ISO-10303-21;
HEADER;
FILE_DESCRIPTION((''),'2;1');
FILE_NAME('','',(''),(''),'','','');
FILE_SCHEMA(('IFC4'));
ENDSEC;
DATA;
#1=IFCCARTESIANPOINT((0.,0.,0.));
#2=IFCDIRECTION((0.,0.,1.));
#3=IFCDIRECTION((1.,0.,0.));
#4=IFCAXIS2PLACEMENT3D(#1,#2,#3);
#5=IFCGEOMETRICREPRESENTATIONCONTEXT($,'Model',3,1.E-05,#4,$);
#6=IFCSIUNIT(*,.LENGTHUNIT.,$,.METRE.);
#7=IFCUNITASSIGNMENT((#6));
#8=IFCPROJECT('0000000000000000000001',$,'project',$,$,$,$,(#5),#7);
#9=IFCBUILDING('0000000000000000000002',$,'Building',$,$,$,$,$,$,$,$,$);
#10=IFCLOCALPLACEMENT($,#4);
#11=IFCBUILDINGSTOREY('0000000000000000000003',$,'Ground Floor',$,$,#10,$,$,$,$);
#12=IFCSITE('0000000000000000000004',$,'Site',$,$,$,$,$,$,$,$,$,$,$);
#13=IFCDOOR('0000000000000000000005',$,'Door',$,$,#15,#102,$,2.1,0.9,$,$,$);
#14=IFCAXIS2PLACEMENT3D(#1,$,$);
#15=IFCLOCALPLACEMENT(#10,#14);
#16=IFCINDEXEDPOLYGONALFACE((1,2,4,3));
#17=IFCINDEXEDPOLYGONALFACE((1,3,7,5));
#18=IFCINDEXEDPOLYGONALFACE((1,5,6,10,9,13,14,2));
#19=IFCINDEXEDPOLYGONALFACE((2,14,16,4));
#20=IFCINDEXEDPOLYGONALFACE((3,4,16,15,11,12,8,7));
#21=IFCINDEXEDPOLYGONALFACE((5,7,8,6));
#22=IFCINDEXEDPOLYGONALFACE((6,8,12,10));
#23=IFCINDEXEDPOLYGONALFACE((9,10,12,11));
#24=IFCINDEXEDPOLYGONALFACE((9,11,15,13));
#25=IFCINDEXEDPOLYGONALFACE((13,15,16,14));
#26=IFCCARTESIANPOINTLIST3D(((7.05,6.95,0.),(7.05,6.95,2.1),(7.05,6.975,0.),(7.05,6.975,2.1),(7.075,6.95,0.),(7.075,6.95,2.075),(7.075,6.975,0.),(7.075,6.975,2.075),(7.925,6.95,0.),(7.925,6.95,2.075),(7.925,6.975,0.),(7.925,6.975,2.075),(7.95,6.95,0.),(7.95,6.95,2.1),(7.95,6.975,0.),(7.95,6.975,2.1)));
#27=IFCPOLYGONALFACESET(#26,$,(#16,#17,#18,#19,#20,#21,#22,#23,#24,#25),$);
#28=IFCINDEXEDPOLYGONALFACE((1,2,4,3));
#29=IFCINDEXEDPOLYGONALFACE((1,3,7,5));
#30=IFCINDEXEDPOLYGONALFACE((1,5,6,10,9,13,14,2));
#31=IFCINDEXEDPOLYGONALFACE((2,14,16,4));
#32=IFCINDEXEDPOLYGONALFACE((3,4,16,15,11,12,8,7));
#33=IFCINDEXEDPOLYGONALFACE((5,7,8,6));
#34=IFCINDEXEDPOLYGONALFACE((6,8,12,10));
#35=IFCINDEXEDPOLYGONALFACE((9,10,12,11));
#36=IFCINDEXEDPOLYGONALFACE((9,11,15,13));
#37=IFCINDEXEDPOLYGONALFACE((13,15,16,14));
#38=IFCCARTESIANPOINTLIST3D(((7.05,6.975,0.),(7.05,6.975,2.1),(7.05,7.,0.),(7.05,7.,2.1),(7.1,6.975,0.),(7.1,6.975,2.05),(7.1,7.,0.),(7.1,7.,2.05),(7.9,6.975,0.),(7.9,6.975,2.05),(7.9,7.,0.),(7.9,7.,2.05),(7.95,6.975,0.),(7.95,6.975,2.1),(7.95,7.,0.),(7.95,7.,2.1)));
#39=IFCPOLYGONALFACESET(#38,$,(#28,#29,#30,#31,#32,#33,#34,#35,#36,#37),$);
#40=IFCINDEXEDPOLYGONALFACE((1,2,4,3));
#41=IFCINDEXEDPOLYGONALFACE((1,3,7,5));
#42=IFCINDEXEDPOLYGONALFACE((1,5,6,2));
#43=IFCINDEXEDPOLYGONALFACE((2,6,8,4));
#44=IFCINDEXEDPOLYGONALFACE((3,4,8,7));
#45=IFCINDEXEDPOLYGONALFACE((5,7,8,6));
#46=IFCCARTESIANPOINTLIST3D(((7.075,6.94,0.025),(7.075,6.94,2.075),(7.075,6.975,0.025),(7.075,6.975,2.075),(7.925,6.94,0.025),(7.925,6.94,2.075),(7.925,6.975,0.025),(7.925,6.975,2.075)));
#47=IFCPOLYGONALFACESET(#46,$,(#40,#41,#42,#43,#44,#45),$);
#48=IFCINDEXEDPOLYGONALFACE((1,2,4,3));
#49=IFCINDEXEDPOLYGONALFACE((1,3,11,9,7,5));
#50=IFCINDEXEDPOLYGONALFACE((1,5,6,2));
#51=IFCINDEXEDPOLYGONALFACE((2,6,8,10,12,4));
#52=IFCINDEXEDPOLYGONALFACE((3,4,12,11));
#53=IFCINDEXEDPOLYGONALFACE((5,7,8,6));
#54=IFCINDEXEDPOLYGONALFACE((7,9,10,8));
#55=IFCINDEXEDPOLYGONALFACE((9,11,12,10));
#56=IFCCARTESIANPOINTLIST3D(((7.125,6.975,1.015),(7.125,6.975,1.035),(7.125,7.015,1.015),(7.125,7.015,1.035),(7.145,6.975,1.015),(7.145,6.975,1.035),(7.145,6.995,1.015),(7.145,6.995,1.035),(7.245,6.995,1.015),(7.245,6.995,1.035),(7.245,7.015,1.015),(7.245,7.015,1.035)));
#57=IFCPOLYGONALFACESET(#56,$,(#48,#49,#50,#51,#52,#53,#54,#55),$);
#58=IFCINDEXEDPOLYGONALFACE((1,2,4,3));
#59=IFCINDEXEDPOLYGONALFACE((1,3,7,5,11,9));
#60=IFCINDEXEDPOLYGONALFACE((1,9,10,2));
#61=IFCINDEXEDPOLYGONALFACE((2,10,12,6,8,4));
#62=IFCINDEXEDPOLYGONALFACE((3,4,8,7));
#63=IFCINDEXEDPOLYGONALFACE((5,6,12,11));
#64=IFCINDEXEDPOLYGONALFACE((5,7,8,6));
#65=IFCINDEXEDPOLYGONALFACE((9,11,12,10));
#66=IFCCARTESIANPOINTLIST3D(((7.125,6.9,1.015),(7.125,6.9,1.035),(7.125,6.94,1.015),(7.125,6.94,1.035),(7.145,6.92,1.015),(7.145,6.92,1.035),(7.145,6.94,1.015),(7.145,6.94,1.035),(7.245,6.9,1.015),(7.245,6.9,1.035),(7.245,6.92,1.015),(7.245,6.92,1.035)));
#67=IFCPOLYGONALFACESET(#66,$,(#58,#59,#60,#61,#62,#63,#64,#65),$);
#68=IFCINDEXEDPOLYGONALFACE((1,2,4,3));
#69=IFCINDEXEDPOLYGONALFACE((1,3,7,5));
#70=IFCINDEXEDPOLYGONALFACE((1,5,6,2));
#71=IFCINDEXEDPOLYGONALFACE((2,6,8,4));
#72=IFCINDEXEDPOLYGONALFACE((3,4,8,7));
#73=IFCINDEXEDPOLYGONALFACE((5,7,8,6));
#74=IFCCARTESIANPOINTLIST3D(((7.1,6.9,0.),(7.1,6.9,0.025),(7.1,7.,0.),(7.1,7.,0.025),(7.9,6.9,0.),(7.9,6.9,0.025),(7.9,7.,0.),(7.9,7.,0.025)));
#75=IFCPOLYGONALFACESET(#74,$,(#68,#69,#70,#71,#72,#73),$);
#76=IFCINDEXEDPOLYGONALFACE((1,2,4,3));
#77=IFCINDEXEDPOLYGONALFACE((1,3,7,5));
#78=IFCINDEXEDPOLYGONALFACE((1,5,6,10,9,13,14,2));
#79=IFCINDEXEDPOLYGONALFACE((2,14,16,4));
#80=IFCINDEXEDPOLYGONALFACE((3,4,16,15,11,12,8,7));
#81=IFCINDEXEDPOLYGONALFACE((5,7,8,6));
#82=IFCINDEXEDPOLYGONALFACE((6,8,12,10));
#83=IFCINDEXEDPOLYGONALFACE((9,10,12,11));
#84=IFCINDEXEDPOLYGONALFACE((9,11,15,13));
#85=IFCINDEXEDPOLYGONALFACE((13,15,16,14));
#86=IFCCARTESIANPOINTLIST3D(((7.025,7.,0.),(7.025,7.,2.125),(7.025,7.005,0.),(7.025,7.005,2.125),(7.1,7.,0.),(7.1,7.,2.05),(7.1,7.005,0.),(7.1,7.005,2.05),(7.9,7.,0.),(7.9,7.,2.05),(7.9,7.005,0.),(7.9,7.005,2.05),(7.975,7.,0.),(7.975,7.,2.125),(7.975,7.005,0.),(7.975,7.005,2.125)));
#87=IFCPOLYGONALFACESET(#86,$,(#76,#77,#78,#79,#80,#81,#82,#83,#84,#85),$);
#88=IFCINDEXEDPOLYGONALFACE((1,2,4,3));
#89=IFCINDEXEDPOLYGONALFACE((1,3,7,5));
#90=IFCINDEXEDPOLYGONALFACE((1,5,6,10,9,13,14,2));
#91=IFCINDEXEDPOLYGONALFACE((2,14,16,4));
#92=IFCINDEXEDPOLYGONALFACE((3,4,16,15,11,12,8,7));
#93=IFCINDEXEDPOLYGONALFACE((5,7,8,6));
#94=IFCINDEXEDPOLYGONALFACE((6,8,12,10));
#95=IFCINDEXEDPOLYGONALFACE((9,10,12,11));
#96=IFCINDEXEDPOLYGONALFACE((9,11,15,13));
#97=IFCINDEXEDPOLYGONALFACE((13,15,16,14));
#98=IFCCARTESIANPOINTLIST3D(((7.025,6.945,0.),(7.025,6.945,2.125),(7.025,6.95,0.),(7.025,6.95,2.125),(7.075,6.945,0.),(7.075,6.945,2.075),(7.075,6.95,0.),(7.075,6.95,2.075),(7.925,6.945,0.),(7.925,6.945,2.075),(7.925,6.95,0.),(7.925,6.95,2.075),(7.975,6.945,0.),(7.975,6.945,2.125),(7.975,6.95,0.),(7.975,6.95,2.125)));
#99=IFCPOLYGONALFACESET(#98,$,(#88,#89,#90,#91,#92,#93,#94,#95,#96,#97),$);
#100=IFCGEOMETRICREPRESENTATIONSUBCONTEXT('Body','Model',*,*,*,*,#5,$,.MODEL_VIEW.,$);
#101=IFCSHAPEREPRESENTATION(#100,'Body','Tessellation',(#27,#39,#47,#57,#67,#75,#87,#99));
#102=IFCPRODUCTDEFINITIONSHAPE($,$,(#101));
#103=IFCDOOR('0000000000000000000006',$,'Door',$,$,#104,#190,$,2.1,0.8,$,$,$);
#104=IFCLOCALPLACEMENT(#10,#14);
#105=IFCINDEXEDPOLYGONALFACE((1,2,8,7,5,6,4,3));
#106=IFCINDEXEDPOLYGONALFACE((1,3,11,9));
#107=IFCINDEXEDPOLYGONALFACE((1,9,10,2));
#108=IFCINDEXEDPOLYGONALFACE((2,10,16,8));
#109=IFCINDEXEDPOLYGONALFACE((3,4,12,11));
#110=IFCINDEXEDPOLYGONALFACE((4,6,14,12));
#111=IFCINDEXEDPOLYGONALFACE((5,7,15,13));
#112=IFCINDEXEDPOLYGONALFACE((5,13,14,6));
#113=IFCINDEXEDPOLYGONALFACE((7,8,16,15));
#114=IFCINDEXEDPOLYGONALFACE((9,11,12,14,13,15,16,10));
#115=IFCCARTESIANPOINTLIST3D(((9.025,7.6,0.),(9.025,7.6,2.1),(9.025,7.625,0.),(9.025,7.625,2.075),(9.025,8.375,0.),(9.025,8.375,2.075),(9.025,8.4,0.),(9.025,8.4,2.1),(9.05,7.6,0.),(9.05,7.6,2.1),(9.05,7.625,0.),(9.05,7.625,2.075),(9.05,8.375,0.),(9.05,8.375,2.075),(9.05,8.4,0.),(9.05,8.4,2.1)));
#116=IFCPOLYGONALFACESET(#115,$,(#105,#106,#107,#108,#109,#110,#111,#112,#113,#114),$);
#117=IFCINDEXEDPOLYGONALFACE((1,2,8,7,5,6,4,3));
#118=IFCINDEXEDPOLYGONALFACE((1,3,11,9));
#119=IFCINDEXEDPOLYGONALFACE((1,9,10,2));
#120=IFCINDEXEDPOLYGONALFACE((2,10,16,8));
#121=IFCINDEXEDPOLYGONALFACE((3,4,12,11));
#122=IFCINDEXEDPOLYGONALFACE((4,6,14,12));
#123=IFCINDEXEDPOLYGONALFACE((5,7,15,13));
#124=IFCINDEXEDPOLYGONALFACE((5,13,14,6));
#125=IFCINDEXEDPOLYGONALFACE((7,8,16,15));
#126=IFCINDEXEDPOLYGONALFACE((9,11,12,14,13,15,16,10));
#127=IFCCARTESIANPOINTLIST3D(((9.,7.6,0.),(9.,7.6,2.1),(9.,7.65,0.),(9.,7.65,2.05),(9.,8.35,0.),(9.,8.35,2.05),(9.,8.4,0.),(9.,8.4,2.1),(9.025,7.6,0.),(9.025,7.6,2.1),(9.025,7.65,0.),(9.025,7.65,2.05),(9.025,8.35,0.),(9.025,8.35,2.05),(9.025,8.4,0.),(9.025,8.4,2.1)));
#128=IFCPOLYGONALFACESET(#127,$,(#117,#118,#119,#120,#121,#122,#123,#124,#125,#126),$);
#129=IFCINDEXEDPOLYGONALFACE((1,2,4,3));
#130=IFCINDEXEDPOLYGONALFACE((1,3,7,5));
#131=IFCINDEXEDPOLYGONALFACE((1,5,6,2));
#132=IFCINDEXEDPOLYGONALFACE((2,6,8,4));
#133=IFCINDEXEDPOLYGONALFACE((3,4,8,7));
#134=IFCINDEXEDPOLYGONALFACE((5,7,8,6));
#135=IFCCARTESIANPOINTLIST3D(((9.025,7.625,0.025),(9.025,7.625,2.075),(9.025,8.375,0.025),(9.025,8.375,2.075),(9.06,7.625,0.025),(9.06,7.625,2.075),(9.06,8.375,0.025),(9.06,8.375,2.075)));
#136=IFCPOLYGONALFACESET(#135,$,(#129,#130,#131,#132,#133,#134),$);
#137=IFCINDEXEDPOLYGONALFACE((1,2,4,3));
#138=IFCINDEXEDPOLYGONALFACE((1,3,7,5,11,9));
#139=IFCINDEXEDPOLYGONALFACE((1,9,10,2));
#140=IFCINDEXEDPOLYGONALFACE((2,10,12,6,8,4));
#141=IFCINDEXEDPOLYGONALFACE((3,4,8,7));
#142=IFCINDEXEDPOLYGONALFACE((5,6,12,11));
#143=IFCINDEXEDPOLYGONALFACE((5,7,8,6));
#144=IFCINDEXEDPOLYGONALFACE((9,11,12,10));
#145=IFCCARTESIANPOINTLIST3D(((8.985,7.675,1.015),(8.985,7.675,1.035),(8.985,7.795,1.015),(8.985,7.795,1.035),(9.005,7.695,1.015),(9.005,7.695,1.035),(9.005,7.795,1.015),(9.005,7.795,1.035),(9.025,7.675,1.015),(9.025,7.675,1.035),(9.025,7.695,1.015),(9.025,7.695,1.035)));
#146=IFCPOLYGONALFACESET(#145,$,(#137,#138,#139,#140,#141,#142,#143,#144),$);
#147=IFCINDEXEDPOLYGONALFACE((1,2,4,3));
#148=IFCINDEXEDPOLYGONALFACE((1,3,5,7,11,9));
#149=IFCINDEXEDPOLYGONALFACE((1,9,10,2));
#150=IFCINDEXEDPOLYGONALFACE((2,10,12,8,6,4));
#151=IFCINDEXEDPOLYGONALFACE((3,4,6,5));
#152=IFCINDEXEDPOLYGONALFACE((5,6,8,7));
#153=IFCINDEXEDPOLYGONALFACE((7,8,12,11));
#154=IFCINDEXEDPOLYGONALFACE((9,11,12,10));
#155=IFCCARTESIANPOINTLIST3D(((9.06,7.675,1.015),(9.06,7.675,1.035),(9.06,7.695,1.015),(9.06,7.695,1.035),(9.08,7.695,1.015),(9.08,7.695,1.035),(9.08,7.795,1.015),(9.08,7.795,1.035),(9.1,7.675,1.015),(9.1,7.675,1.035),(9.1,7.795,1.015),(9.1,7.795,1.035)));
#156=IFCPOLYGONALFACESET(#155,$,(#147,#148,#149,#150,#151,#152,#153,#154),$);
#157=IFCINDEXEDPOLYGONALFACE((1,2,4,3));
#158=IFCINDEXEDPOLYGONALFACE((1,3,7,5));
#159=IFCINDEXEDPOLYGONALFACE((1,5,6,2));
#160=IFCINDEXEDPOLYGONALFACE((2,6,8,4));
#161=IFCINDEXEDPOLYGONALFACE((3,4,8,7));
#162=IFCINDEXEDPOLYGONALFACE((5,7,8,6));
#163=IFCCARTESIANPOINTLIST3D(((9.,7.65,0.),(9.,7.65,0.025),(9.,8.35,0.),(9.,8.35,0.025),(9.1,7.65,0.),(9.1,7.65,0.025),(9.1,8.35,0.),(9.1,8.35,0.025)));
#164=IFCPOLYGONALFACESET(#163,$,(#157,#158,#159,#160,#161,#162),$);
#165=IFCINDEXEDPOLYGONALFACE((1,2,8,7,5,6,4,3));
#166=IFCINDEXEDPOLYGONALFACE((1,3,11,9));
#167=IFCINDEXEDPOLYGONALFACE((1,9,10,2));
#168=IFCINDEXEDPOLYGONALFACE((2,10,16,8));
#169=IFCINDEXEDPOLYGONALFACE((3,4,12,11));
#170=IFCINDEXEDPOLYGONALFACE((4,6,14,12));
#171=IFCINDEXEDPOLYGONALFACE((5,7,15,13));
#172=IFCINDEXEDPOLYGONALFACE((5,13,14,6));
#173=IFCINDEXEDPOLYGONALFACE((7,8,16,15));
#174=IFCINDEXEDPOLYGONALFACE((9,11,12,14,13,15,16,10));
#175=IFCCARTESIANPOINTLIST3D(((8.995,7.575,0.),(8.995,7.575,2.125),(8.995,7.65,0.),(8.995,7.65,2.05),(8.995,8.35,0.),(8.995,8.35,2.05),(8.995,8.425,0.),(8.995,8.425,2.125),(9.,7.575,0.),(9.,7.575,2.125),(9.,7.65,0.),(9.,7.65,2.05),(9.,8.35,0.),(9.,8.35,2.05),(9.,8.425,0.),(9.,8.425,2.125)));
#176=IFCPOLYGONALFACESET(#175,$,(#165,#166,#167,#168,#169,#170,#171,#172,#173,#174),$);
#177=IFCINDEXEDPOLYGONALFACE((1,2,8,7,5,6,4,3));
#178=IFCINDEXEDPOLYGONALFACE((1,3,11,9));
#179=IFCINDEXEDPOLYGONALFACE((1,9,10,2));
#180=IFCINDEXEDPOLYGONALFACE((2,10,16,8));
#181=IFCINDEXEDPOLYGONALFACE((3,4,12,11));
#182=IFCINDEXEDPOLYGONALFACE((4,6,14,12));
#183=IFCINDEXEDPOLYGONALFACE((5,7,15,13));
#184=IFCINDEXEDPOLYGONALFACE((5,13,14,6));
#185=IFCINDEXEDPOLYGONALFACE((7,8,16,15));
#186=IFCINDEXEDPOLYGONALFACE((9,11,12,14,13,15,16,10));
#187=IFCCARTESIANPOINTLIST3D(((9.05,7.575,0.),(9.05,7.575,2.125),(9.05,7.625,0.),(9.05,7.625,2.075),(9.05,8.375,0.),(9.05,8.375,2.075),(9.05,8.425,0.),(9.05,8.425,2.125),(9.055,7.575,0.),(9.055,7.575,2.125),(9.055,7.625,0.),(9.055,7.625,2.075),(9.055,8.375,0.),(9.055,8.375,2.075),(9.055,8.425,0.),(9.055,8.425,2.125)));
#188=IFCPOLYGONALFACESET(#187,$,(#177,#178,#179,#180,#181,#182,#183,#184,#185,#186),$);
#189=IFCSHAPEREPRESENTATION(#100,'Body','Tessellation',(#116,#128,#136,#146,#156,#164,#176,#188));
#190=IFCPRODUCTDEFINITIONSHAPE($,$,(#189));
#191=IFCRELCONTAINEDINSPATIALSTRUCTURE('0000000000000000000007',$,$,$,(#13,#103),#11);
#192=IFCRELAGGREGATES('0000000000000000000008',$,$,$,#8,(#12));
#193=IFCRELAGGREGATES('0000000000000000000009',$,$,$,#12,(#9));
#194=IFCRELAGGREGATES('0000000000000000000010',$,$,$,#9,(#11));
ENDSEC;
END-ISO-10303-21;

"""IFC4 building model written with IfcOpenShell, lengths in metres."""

from ifc_helpers import new_model, si_unit, frame, origin_with_axes, place, context, subcontext, project, spatial, line, indexed_curve, outline, extrude, element, save


model = new_model("IFC4")

# Units and contexts
model_context = context("Model", 3, precision=1e-05, world=origin_with_axes())
body_context = subcontext(model_context, "Body", "Model", "MODEL_VIEW")
ifc_project = project(units=[si_unit("LENGTHUNIT", "METRE")], contexts=[model_context])

# Site, building, storey
site = spatial("IfcSite", under=ifc_project, Name="Site")
building = spatial("IfcBuilding", under=site, Name="Building")
storey_placement = place(None, origin_with_axes())
storey = spatial("IfcBuildingStorey", under=building, at=storey_placement, Name="Ground Floor")

# Doors
door_1_placement = place(storey_placement, frame((7.95, 7.0, 0.0), z_axis=(0.0, 0.0, 1.0), x_axis=(-1.0, 0.0, 0.0)))
element("IfcDoor", 1, at=door_1_placement, inside=storey, Name="Door", OverallHeight=2.1, OverallWidth=0.9, context=body_context, shape_type="SweptSolid", body=[
    extrude(outline(indexed_curve([(0.0, 0.0), (0.0, 2.1), (0.9, 2.1), (0.9, 0.0), (0.875, 0.0), (0.875, 2.075), (0.025, 2.075), (0.025, 0.0)], segments=[line(1, 2, 3, 4, 5, 6, 7, 8, 1)])), frame((0.0, 0.025, 0.0), z_axis=(0.0, -1.0, 0.0), x_axis=(1.0, 0.0, 0.0)), (0.0, 0.0, -1.0), 0.025),
    extrude(outline(indexed_curve([(0.0, 0.0), (0.0, 2.1), (0.9, 2.1), (0.9, 0.0), (0.85, 0.0), (0.85, 2.05), (0.05, 2.05), (0.05, 0.0)], segments=[line(1, 2, 3, 4, 5, 6, 7, 8, 1)])), frame((0.0, 0.0, 0.0), z_axis=(0.0, -1.0, 0.0), x_axis=(1.0, 0.0, 0.0)), (0.0, 0.0, -1.0), 0.025),
    extrude(outline(indexed_curve([(0.0, 0.0), (0.85, 0.0), (0.85, 0.035), (0.0, 0.035)], segments=[line(1, 2, 3, 4, 1)])), frame((0.025, 0.025, 0.025), z_axis=(0.0, 0.0, 1.0), x_axis=(1.0, 0.0, 0.0)), (0.0, 0.0, 1.0), 2.05),
    extrude(outline(indexed_curve([(0.0, 0.0), (0.0, -0.04), (-0.12, -0.04), (-0.12, -0.02), (-0.02, -0.02), (-0.02, 0.0)], segments=[line(1, 2, 3, 4, 5, 6, 1)])), frame((0.825, 0.025, 1.015), z_axis=(0.0, 0.0, 1.0), x_axis=(1.0, 0.0, 0.0)), (0.0, 0.0, 1.0), 0.02),
    extrude(outline(indexed_curve([(0.0, 0.0), (0.0, 0.04), (-0.12, 0.04), (-0.12, 0.02), (-0.02, 0.02), (-0.02, 0.0)], segments=[line(1, 2, 3, 4, 5, 6, 1)])), frame((0.825, 0.06, 1.015), z_axis=(0.0, 0.0, 1.0), x_axis=(1.0, 0.0, 0.0)), (0.0, 0.0, 1.0), 0.02),
    extrude(outline(indexed_curve([(0.0, 0.0), (0.8, 0.0), (0.8, 0.1), (0.0, 0.1)], segments=[line(1, 2, 3, 4, 1)])), frame((0.05, 0.0, 0.0), z_axis=(0.0, 0.0, 1.0), x_axis=(1.0, 0.0, 0.0)), (0.0, 0.0, 1.0), 0.025),
    extrude(outline(indexed_curve([(0.0, 0.0), (0.0, 2.125), (0.95, 2.125), (0.95, 0.0), (0.875, 0.0), (0.875, 2.05), (0.075, 2.05), (0.075, 0.0)], segments=[line(1, 2, 3, 4, 5, 6, 7, 8, 1)])), frame((-0.025, -0.005, 0.0), z_axis=(0.0, -1.0, 0.0), x_axis=(1.0, 0.0, 0.0)), (0.0, 0.0, -1.0), 0.005),
    extrude(outline(indexed_curve([(0.0, 0.0), (0.0, 2.125), (0.95, 2.125), (0.95, 0.0), (0.9, 0.0), (0.9, 2.075), (0.05, 2.075), (0.05, 0.0)], segments=[line(1, 2, 3, 4, 5, 6, 7, 8, 1)])), frame((-0.025, 0.05, 0.0), z_axis=(0.0, -1.0, 0.0), x_axis=(1.0, 0.0, 0.0)), (0.0, 0.0, -1.0), 0.005),
])
door_2_placement = place(storey_placement, frame((9.0, 8.4, 0.0), z_axis=(0.0, 0.0, 1.0), x_axis=(0.0, -1.0, 0.0)))
element("IfcDoor", 2, at=door_2_placement, inside=storey, Name="Door", OverallHeight=2.1, OverallWidth=0.8, context=body_context, shape_type="SweptSolid", body=[
    extrude(outline(indexed_curve([(0.0, 0.0), (0.0, 2.1), (0.8, 2.1), (0.8, 0.0), (0.775, 0.0), (0.775, 2.075), (0.025, 2.075), (0.025, 0.0)], segments=[line(1, 2, 3, 4, 5, 6, 7, 8, 1)])), frame((0.0, 0.025, 0.0), z_axis=(0.0, -1.0, 0.0), x_axis=(1.0, 0.0, 0.0)), (0.0, 0.0, -1.0), 0.025),
    extrude(outline(indexed_curve([(0.0, 0.0), (0.0, 2.1), (0.8, 2.1), (0.8, 0.0), (0.75, 0.0), (0.75, 2.05), (0.05, 2.05), (0.05, 0.0)], segments=[line(1, 2, 3, 4, 5, 6, 7, 8, 1)])), frame((0.0, 0.0, 0.0), z_axis=(0.0, -1.0, 0.0), x_axis=(1.0, 0.0, 0.0)), (0.0, 0.0, -1.0), 0.025),
    extrude(outline(indexed_curve([(0.0, 0.0), (0.75, 0.0), (0.75, 0.035), (0.0, 0.035)], segments=[line(1, 2, 3, 4, 1)])), frame((0.025, 0.025, 0.025), z_axis=(0.0, 0.0, 1.0), x_axis=(1.0, 0.0, 0.0)), (0.0, 0.0, 1.0), 2.05),
    extrude(outline(indexed_curve([(0.0, 0.0), (0.0, -0.04), (-0.12, -0.04), (-0.12, -0.02), (-0.02, -0.02), (-0.02, 0.0)], segments=[line(1, 2, 3, 4, 5, 6, 1)])), frame((0.725, 0.025, 1.015), z_axis=(0.0, 0.0, 1.0), x_axis=(1.0, 0.0, 0.0)), (0.0, 0.0, 1.0), 0.02),
    extrude(outline(indexed_curve([(0.0, 0.0), (0.0, 0.04), (-0.12, 0.04), (-0.12, 0.02), (-0.02, 0.02), (-0.02, 0.0)], segments=[line(1, 2, 3, 4, 5, 6, 1)])), frame((0.725, 0.06, 1.015), z_axis=(0.0, 0.0, 1.0), x_axis=(1.0, 0.0, 0.0)), (0.0, 0.0, 1.0), 0.02),
    extrude(outline(indexed_curve([(0.0, 0.0), (0.7, 0.0), (0.7, 0.1), (0.0, 0.1)], segments=[line(1, 2, 3, 4, 1)])), frame((0.05, 0.0, 0.0), z_axis=(0.0, 0.0, 1.0), x_axis=(1.0, 0.0, 0.0)), (0.0, 0.0, 1.0), 0.025),
    extrude(outline(indexed_curve([(0.0, 0.0), (0.0, 2.125), (0.85, 2.125), (0.85, 0.0), (0.775, 0.0), (0.775, 2.05), (0.075, 2.05), (0.075, 0.0)], segments=[line(1, 2, 3, 4, 5, 6, 7, 8, 1)])), frame((-0.025, -0.005, 0.0), z_axis=(0.0, -1.0, 0.0), x_axis=(1.0, 0.0, 0.0)), (0.0, 0.0, -1.0), 0.005),
    extrude(outline(indexed_curve([(0.0, 0.0), (0.0, 2.125), (0.85, 2.125), (0.85, 0.0), (0.8, 0.0), (0.8, 2.075), (0.05, 2.075), (0.05, 0.0)], segments=[line(1, 2, 3, 4, 5, 6, 7, 8, 1)])), frame((-0.025, 0.05, 0.0), z_axis=(0.0, -1.0, 0.0), x_axis=(1.0, 0.0, 0.0)), (0.0, 0.0, -1.0), 0.005),
])

save(model, "model.ifc")
